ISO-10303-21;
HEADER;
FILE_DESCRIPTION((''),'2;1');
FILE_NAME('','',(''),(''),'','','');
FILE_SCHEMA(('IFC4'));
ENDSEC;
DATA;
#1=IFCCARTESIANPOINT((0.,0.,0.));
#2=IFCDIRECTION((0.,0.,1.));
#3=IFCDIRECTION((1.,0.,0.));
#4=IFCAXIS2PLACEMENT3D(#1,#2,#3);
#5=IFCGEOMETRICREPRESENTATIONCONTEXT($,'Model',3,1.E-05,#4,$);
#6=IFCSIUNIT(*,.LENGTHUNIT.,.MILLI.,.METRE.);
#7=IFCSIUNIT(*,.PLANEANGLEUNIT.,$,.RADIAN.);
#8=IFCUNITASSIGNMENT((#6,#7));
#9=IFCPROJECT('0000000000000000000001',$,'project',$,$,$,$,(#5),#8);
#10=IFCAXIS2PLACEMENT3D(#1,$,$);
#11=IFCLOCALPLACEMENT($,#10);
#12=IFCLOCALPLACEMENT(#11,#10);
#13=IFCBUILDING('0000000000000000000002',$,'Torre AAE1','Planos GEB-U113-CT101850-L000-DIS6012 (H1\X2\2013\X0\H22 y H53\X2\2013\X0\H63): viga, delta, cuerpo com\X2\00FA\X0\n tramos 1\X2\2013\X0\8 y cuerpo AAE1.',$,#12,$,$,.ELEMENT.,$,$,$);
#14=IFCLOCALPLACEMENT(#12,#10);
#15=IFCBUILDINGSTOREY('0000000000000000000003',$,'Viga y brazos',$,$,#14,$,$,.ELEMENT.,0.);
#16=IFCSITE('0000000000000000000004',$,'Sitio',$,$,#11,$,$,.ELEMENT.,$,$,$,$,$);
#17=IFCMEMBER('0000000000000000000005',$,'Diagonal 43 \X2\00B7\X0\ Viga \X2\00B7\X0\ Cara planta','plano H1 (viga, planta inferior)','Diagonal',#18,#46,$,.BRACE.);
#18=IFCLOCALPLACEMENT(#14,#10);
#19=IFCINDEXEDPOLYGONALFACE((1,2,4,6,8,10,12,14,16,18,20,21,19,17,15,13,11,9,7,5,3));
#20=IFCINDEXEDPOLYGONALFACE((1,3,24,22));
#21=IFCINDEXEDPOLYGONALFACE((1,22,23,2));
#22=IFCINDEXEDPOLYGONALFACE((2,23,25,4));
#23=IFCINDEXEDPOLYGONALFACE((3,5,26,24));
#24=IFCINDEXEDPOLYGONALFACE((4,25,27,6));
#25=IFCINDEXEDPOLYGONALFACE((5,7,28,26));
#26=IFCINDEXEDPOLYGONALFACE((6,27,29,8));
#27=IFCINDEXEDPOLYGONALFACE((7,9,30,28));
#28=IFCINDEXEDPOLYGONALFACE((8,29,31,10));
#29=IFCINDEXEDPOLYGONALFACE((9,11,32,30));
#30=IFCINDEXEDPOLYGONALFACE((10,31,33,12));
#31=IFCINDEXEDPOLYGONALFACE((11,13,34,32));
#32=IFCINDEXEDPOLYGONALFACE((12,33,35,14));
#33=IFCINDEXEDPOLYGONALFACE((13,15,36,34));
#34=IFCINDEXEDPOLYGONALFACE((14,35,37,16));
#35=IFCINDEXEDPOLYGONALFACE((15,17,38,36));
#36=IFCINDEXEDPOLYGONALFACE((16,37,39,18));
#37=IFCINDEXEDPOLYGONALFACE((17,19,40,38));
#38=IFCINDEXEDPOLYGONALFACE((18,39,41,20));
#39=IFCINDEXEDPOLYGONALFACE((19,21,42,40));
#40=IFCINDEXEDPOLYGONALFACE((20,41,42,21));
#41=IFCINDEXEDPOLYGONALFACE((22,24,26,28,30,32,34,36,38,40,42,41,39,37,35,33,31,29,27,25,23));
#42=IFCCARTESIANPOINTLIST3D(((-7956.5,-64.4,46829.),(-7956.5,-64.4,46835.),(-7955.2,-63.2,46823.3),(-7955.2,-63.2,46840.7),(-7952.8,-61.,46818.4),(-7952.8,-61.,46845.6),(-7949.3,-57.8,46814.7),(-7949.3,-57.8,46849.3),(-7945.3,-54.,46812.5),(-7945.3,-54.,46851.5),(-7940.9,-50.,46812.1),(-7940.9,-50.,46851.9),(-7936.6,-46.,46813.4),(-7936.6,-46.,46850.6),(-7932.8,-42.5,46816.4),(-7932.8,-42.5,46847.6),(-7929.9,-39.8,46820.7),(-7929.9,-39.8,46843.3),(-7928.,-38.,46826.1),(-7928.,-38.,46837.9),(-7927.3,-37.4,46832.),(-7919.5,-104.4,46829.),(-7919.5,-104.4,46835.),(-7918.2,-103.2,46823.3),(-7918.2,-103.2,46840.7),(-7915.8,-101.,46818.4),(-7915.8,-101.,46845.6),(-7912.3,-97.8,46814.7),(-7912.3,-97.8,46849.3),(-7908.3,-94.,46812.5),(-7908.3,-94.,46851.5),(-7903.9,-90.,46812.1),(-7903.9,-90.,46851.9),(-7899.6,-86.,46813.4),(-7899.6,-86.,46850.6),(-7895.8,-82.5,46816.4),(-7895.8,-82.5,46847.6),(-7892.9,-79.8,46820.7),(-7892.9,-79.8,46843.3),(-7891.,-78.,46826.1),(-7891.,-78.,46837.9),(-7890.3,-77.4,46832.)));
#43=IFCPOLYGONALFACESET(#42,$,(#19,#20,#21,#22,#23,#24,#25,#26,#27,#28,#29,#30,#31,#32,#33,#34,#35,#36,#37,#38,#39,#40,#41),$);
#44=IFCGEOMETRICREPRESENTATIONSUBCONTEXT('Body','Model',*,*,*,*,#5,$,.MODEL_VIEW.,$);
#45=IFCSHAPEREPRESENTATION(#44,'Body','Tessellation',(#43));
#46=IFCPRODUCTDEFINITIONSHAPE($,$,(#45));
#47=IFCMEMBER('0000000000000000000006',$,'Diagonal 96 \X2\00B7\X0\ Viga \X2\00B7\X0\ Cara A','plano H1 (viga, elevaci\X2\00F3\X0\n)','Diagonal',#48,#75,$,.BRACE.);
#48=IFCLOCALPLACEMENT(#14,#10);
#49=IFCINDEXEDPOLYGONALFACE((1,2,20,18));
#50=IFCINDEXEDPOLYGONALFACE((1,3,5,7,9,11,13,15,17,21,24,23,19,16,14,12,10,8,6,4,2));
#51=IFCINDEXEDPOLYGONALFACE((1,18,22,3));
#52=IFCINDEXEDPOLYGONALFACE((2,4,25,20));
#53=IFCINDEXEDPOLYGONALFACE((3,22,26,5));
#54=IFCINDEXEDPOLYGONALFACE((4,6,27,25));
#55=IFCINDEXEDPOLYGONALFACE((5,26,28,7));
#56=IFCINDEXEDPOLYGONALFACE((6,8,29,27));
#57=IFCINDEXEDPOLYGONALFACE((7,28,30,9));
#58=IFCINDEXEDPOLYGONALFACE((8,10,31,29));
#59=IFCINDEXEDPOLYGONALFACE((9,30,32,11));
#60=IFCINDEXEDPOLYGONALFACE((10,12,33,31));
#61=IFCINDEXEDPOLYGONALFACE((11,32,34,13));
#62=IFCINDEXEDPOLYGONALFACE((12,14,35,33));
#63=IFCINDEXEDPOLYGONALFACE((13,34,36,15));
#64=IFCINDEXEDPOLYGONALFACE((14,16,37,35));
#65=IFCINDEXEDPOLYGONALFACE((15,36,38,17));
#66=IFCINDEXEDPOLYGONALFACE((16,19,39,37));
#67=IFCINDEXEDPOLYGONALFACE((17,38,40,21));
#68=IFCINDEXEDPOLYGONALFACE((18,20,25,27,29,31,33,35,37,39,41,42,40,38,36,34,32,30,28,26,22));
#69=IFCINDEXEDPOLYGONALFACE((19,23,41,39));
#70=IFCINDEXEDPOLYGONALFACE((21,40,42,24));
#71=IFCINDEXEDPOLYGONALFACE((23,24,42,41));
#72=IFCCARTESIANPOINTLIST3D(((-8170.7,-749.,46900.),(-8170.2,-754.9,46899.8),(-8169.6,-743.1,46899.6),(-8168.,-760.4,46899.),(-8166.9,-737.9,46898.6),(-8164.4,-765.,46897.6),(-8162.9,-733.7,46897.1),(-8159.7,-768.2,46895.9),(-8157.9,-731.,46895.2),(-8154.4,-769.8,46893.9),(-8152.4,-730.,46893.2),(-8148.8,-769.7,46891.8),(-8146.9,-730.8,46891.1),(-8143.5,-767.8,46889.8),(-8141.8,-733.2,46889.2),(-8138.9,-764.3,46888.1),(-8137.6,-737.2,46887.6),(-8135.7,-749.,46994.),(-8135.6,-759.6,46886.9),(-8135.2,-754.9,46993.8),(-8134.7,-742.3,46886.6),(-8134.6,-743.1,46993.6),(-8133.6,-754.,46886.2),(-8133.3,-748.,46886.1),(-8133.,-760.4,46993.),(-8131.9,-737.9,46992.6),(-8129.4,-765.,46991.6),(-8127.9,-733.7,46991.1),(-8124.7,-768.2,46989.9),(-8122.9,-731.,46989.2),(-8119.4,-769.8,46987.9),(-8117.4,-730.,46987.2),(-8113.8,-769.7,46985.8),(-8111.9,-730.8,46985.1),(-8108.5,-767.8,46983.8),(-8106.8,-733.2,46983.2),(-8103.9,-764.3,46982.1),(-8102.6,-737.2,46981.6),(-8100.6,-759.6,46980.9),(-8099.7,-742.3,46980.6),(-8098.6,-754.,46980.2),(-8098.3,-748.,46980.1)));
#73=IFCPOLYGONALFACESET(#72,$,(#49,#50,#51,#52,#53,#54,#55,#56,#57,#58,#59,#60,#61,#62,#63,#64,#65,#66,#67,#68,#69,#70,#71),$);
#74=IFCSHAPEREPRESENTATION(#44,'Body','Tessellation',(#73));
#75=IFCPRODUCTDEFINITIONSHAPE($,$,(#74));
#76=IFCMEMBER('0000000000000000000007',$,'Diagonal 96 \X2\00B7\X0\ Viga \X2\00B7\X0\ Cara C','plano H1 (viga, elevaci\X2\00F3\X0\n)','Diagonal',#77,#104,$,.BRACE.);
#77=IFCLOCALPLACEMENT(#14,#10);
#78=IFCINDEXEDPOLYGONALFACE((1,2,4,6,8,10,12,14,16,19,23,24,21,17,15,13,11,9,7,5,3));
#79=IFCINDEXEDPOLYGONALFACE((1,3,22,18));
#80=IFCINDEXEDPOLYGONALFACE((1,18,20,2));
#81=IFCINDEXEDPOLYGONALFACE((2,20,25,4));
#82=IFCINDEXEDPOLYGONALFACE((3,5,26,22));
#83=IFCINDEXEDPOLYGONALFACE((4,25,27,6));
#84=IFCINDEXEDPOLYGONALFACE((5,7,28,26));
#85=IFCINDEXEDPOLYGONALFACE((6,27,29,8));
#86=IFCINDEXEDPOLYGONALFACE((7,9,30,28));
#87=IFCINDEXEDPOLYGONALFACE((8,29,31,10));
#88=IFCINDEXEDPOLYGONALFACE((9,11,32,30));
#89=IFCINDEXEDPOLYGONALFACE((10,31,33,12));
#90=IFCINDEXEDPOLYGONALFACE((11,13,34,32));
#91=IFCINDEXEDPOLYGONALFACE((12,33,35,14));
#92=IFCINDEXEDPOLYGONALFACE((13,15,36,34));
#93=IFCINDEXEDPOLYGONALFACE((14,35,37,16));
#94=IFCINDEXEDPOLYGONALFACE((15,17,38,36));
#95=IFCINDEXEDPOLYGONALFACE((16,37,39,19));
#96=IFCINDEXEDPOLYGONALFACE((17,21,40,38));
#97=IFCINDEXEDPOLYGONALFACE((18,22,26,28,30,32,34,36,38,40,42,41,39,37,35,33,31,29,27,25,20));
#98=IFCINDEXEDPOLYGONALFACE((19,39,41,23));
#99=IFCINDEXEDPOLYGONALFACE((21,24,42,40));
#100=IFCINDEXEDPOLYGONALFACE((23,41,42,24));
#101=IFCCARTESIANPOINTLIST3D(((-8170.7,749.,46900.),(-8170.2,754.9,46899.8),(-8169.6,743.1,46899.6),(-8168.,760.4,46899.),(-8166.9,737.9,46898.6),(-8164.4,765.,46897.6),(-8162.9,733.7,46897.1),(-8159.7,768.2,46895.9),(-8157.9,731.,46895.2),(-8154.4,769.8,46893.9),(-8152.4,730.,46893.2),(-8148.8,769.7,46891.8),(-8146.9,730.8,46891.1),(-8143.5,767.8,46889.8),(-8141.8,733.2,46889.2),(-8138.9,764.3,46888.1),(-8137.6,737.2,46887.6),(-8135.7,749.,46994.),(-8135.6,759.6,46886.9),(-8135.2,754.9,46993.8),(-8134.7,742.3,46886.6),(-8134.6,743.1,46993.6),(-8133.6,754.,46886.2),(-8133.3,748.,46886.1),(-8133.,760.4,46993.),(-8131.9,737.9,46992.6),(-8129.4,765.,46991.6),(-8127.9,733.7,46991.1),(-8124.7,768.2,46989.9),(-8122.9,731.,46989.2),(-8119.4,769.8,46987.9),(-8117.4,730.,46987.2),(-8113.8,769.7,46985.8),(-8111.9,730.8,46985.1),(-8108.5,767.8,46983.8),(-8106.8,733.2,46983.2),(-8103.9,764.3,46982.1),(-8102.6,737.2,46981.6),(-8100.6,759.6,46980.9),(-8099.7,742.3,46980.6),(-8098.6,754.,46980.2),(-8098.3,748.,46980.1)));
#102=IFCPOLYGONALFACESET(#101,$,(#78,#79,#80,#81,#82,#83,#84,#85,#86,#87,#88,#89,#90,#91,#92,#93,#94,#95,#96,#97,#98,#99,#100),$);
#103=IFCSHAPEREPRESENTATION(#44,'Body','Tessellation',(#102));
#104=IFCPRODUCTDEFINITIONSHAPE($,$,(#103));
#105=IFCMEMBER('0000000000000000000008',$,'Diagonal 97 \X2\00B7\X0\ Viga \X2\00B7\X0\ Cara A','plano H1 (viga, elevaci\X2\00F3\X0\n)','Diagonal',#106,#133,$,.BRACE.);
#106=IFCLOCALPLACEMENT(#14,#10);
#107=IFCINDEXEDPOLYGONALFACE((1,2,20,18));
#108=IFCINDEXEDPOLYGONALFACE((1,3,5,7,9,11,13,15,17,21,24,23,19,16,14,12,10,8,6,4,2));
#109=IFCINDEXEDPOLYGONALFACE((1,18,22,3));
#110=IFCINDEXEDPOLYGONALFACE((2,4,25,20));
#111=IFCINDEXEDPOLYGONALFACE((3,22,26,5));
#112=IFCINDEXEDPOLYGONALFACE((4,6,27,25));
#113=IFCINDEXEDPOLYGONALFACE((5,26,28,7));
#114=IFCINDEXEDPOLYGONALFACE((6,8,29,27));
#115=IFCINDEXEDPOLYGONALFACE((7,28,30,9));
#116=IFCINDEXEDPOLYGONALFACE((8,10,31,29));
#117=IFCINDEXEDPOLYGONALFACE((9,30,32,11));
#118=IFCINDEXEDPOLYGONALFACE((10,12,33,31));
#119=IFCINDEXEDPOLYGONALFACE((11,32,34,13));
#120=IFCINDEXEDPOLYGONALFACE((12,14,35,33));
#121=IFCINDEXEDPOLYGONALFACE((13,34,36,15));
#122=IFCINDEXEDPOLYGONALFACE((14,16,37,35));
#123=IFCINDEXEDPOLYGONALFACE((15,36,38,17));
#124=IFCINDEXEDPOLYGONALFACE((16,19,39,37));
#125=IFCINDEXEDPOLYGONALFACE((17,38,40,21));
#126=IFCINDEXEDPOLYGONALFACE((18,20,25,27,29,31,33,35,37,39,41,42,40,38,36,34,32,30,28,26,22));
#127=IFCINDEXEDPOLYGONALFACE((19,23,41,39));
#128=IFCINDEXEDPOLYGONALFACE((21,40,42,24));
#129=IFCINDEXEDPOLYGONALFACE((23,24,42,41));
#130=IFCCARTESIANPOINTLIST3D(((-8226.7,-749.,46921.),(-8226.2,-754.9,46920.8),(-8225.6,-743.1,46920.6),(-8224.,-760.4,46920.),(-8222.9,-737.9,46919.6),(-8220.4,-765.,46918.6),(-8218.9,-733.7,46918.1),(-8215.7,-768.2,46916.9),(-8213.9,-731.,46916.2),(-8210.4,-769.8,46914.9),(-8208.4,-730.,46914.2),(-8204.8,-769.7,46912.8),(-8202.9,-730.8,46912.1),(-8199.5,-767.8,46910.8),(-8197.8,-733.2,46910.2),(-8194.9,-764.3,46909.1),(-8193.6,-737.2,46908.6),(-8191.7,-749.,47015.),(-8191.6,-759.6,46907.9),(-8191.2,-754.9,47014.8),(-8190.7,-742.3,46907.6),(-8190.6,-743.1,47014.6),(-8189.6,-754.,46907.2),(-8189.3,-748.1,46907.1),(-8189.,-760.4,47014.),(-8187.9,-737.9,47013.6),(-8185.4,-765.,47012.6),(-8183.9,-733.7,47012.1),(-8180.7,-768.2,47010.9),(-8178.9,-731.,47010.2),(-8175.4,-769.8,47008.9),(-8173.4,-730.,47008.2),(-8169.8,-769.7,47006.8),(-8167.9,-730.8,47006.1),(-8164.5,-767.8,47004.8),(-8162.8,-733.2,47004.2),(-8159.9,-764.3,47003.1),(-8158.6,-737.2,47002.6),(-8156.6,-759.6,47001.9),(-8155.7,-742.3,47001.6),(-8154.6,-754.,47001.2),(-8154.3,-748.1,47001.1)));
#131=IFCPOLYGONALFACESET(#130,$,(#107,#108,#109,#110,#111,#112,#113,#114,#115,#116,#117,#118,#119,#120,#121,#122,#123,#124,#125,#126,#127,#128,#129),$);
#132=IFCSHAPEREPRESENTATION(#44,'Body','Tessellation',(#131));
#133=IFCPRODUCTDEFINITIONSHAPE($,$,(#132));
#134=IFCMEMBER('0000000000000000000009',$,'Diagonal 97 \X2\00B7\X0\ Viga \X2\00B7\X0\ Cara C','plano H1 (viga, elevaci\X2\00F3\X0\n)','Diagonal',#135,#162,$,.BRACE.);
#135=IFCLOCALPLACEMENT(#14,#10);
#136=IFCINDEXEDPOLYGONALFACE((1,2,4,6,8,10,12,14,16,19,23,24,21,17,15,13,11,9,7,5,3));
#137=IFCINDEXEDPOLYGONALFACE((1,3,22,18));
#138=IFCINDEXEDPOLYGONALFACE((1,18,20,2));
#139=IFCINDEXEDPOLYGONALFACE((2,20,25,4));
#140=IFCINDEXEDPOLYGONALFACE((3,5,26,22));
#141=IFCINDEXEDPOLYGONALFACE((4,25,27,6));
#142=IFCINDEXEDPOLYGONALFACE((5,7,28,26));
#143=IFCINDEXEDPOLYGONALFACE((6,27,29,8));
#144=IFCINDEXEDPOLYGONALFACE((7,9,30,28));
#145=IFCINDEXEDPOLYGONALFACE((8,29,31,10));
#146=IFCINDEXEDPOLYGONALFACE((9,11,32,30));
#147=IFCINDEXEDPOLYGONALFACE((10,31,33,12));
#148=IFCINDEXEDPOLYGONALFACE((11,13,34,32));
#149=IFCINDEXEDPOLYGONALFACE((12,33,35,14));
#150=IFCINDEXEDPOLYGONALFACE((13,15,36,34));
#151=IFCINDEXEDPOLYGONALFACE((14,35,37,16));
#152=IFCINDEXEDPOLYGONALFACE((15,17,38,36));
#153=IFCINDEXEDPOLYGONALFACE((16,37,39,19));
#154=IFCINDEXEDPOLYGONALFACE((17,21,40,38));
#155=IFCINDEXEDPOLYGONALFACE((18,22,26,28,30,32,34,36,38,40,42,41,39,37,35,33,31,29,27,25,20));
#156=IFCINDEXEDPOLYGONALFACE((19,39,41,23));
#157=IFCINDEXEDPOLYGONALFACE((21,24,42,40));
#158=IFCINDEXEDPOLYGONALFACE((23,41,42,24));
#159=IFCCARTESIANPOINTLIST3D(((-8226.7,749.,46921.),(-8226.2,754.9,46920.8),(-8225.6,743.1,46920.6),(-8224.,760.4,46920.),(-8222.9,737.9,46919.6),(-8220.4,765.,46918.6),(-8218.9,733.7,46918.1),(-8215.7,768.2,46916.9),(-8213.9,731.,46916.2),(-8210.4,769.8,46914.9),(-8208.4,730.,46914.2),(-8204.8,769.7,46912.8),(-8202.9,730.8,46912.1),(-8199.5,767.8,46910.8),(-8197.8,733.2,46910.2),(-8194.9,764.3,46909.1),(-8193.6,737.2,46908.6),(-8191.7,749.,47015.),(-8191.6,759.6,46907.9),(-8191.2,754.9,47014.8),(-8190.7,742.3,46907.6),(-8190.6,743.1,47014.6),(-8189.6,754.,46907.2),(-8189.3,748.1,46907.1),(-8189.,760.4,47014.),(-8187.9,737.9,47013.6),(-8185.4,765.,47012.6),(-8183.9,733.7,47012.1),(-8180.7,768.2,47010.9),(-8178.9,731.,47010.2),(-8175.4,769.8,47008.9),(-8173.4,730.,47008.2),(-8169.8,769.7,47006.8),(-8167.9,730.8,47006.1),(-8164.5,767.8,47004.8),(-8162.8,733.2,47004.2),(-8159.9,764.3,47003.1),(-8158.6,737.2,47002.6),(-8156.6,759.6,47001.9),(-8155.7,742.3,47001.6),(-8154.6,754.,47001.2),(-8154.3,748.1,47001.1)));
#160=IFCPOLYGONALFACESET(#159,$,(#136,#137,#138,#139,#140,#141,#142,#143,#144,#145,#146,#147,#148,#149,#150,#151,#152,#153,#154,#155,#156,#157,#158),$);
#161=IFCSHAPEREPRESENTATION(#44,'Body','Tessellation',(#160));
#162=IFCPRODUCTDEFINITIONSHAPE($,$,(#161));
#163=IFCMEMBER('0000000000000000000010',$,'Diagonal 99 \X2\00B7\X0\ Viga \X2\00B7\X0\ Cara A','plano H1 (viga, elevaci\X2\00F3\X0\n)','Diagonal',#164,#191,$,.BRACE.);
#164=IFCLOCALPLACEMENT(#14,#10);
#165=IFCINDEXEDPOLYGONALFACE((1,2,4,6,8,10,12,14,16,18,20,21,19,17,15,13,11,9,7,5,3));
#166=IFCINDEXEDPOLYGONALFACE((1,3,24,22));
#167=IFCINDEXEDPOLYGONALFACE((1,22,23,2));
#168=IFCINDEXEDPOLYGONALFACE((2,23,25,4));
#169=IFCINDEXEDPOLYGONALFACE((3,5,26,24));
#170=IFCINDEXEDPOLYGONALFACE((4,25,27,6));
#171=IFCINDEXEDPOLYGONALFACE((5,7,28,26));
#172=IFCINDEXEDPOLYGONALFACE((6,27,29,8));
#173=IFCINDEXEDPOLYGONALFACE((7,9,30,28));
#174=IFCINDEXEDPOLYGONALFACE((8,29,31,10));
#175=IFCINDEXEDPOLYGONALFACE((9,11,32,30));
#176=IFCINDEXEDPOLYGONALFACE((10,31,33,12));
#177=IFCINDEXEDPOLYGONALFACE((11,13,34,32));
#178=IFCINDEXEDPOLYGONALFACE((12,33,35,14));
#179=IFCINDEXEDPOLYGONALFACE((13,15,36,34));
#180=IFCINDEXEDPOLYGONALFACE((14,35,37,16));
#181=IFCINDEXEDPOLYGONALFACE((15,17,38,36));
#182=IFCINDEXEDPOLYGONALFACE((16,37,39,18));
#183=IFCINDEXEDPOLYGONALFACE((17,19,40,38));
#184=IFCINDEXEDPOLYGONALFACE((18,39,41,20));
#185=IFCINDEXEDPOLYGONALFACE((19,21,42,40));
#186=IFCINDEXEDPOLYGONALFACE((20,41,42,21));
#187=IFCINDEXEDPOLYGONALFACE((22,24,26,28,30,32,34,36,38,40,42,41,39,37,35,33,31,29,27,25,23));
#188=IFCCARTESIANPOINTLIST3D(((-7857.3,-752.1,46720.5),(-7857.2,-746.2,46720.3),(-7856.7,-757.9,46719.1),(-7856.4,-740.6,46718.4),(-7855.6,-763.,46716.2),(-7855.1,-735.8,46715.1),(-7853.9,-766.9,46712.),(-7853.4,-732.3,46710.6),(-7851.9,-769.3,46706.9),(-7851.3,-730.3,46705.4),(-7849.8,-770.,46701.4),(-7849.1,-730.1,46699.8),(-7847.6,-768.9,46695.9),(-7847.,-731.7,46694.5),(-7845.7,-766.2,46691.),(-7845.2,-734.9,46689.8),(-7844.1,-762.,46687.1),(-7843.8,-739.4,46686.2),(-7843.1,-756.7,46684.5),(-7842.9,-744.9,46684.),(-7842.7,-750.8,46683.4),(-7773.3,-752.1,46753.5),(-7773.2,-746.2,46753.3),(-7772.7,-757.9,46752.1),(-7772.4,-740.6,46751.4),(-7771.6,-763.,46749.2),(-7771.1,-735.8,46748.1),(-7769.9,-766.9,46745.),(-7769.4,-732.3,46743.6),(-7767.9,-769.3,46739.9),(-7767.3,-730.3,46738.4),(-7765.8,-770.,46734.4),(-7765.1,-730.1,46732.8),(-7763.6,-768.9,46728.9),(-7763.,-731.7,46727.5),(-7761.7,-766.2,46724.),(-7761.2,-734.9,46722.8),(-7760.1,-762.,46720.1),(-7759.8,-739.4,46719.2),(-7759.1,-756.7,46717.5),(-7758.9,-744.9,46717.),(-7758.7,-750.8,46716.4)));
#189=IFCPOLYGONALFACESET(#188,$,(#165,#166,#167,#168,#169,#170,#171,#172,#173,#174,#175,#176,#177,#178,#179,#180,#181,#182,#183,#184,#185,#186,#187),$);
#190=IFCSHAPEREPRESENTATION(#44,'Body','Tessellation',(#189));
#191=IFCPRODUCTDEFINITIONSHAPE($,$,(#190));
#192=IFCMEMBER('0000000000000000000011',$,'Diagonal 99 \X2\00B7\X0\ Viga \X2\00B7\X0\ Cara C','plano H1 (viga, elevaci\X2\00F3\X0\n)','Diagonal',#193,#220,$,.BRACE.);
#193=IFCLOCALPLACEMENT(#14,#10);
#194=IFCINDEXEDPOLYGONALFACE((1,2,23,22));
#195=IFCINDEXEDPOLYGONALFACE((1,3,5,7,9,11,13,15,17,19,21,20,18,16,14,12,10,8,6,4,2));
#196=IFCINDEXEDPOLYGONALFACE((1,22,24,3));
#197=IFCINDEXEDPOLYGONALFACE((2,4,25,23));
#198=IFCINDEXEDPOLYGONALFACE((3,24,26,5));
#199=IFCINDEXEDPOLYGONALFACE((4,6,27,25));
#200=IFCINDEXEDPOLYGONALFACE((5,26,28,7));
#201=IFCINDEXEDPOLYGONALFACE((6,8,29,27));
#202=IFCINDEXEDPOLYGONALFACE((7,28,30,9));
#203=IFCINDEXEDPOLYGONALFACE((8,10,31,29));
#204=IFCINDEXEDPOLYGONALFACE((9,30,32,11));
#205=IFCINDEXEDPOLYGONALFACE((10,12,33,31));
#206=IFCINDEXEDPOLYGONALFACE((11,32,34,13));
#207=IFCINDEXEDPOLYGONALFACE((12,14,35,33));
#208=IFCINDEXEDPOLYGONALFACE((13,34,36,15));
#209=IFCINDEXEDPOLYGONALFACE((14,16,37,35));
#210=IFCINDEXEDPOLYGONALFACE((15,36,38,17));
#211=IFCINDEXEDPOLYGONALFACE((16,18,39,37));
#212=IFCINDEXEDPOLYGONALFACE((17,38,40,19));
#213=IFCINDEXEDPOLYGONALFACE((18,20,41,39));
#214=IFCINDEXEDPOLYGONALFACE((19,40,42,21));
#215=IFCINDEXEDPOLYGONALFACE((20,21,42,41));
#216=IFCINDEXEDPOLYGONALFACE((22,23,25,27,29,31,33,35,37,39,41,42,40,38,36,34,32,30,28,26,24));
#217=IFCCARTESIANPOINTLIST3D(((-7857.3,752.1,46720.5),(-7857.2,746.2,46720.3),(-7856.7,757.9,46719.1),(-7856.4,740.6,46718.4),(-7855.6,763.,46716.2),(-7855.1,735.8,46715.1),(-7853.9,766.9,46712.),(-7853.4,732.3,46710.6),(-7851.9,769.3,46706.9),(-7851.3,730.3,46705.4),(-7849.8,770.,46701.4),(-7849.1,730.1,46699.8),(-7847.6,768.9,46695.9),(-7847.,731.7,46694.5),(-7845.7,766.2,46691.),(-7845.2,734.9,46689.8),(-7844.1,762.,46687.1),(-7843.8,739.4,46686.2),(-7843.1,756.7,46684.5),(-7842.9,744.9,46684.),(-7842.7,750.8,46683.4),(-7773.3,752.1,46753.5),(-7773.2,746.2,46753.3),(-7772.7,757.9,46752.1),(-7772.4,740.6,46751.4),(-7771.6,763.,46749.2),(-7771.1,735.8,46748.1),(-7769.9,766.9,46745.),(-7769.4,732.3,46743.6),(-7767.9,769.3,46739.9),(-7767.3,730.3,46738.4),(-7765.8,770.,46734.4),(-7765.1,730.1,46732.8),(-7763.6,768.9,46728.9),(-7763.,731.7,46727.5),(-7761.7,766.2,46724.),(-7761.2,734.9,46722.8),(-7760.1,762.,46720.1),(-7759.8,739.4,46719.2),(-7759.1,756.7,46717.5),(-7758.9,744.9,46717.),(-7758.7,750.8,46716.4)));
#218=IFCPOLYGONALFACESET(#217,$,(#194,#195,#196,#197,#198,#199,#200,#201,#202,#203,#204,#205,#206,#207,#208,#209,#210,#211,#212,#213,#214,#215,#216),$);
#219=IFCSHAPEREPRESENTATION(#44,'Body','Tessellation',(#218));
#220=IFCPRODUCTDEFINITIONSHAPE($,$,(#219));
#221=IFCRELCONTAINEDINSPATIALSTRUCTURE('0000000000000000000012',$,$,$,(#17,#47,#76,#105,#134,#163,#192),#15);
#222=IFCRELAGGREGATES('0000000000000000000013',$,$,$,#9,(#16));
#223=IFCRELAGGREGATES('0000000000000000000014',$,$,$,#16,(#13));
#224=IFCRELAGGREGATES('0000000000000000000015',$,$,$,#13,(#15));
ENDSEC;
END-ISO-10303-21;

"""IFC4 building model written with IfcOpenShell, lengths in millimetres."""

from ifc_helpers import new_model, si_unit, frame, origin, origin_with_axes, place, context, subcontext, project, spatial, circle, extrude, element, save


model = new_model("IFC4")

# Units and contexts
model_context = context("Model", 3, precision=1e-05, world=origin_with_axes())
body_context = subcontext(model_context, "Body", "Model", "MODEL_VIEW")
ifc_project = project(units=[si_unit("LENGTHUNIT", "METRE", prefix="MILLI"), si_unit("PLANEANGLEUNIT", "RADIAN")], contexts=[model_context])

# Site, building, storey
site_placement = place(None, origin())
site = spatial("IfcSite", under=ifc_project, at=site_placement, Name="Sitio", CompositionType="ELEMENT")
building_placement = place(site_placement, origin())
building = spatial("IfcBuilding", under=site, at=building_placement, Name="Torre AAE1", Description="Planos GEB-U113-CT101850-L000-DIS6012 (H1–H22 y H53–H63): viga, delta, cuerpo común tramos 1–8 y cuerpo AAE1.", CompositionType="ELEMENT")
storey_placement = place(building_placement, origin())
storey = spatial("IfcBuildingStorey", under=building, at=storey_placement, Name="Viga y brazos", CompositionType="ELEMENT", Elevation=0.0)

# Members
for number, where, z_axis, x_axis, name in (
    (1, (-7905.0, -91.0, 46832.0), (-0.679042, 0.734099, 0.0), (0.734099, 0.679042, 0.0), "Diagonal 43 · Viga · Cara planta"),
):
    element("IfcMember", number, at=place(storey_placement, frame(where, z_axis=z_axis, x_axis=x_axis)), inside=storey, Name=name, Description="plano H1 (viga, planta inferior)", ObjectType="Diagonal", PredefinedType="BRACE", context=body_context, shape_type="SweptSolid", body=[
        extrude(circle(Radius=20.0), None, (0.0, 0.0, 1.0), 54.5),
    ])
for number, where, z_axis, x_axis, name in (
    (2, (-8152.0, -750.0, 46893.0), (0.348937, 0.0, 0.937146), (0.932643, 0.097911, -0.347261), "Diagonal 96 · Viga · Cara A"),
    (3, (-8152.0, 750.0, 46893.0), (0.348937, 0.0, 0.937146), (0.932643, -0.097911, -0.347261), "Diagonal 96 · Viga · Cara C"),
    (4, (-8208.0, -750.0, 46914.0), (0.348937, 0.0, 0.937146), (0.932704, 0.097248, -0.347283), "Diagonal 97 · Viga · Cara A"),
    (5, (-8208.0, 750.0, 46914.0), (0.348937, 0.0, 0.937146), (0.932704, -0.097248, -0.347283), "Diagonal 97 · Viga · Cara C"),
):
    element("IfcMember", number, at=place(storey_placement, frame(where, z_axis=z_axis, x_axis=x_axis)), inside=storey, Name=name, Description="plano H1 (viga, elevación)", ObjectType="Diagonal", PredefinedType="BRACE", context=body_context, shape_type="SweptSolid", body=[
        extrude(circle(Radius=20.0), None, (0.0, 0.0, 1.0), 100.3),
    ])
for number, where, z_axis, x_axis, name in (
    (6, (-7766.0, -750.0, 46735.0), (-0.930751, 0.0, -0.365652), (0.353653, 0.254075, -0.900208), "Diagonal 99 · Viga · Cara A"),
    (7, (-7766.0, 750.0, 46735.0), (-0.930751, 0.0, -0.365652), (0.353653, -0.254075, -0.900208), "Diagonal 99 · Viga · Cara C"),
):
    element("IfcMember", number, at=place(storey_placement, frame(where, z_axis=z_axis, x_axis=x_axis)), inside=storey, Name=name, Description="plano H1 (viga, elevación)", ObjectType="Diagonal", PredefinedType="BRACE", context=body_context, shape_type="SweptSolid", body=[
        extrude(circle(Radius=20.0), None, (0.0, 0.0, 1.0), 90.2),
    ])

save(model, "model.ifc")
